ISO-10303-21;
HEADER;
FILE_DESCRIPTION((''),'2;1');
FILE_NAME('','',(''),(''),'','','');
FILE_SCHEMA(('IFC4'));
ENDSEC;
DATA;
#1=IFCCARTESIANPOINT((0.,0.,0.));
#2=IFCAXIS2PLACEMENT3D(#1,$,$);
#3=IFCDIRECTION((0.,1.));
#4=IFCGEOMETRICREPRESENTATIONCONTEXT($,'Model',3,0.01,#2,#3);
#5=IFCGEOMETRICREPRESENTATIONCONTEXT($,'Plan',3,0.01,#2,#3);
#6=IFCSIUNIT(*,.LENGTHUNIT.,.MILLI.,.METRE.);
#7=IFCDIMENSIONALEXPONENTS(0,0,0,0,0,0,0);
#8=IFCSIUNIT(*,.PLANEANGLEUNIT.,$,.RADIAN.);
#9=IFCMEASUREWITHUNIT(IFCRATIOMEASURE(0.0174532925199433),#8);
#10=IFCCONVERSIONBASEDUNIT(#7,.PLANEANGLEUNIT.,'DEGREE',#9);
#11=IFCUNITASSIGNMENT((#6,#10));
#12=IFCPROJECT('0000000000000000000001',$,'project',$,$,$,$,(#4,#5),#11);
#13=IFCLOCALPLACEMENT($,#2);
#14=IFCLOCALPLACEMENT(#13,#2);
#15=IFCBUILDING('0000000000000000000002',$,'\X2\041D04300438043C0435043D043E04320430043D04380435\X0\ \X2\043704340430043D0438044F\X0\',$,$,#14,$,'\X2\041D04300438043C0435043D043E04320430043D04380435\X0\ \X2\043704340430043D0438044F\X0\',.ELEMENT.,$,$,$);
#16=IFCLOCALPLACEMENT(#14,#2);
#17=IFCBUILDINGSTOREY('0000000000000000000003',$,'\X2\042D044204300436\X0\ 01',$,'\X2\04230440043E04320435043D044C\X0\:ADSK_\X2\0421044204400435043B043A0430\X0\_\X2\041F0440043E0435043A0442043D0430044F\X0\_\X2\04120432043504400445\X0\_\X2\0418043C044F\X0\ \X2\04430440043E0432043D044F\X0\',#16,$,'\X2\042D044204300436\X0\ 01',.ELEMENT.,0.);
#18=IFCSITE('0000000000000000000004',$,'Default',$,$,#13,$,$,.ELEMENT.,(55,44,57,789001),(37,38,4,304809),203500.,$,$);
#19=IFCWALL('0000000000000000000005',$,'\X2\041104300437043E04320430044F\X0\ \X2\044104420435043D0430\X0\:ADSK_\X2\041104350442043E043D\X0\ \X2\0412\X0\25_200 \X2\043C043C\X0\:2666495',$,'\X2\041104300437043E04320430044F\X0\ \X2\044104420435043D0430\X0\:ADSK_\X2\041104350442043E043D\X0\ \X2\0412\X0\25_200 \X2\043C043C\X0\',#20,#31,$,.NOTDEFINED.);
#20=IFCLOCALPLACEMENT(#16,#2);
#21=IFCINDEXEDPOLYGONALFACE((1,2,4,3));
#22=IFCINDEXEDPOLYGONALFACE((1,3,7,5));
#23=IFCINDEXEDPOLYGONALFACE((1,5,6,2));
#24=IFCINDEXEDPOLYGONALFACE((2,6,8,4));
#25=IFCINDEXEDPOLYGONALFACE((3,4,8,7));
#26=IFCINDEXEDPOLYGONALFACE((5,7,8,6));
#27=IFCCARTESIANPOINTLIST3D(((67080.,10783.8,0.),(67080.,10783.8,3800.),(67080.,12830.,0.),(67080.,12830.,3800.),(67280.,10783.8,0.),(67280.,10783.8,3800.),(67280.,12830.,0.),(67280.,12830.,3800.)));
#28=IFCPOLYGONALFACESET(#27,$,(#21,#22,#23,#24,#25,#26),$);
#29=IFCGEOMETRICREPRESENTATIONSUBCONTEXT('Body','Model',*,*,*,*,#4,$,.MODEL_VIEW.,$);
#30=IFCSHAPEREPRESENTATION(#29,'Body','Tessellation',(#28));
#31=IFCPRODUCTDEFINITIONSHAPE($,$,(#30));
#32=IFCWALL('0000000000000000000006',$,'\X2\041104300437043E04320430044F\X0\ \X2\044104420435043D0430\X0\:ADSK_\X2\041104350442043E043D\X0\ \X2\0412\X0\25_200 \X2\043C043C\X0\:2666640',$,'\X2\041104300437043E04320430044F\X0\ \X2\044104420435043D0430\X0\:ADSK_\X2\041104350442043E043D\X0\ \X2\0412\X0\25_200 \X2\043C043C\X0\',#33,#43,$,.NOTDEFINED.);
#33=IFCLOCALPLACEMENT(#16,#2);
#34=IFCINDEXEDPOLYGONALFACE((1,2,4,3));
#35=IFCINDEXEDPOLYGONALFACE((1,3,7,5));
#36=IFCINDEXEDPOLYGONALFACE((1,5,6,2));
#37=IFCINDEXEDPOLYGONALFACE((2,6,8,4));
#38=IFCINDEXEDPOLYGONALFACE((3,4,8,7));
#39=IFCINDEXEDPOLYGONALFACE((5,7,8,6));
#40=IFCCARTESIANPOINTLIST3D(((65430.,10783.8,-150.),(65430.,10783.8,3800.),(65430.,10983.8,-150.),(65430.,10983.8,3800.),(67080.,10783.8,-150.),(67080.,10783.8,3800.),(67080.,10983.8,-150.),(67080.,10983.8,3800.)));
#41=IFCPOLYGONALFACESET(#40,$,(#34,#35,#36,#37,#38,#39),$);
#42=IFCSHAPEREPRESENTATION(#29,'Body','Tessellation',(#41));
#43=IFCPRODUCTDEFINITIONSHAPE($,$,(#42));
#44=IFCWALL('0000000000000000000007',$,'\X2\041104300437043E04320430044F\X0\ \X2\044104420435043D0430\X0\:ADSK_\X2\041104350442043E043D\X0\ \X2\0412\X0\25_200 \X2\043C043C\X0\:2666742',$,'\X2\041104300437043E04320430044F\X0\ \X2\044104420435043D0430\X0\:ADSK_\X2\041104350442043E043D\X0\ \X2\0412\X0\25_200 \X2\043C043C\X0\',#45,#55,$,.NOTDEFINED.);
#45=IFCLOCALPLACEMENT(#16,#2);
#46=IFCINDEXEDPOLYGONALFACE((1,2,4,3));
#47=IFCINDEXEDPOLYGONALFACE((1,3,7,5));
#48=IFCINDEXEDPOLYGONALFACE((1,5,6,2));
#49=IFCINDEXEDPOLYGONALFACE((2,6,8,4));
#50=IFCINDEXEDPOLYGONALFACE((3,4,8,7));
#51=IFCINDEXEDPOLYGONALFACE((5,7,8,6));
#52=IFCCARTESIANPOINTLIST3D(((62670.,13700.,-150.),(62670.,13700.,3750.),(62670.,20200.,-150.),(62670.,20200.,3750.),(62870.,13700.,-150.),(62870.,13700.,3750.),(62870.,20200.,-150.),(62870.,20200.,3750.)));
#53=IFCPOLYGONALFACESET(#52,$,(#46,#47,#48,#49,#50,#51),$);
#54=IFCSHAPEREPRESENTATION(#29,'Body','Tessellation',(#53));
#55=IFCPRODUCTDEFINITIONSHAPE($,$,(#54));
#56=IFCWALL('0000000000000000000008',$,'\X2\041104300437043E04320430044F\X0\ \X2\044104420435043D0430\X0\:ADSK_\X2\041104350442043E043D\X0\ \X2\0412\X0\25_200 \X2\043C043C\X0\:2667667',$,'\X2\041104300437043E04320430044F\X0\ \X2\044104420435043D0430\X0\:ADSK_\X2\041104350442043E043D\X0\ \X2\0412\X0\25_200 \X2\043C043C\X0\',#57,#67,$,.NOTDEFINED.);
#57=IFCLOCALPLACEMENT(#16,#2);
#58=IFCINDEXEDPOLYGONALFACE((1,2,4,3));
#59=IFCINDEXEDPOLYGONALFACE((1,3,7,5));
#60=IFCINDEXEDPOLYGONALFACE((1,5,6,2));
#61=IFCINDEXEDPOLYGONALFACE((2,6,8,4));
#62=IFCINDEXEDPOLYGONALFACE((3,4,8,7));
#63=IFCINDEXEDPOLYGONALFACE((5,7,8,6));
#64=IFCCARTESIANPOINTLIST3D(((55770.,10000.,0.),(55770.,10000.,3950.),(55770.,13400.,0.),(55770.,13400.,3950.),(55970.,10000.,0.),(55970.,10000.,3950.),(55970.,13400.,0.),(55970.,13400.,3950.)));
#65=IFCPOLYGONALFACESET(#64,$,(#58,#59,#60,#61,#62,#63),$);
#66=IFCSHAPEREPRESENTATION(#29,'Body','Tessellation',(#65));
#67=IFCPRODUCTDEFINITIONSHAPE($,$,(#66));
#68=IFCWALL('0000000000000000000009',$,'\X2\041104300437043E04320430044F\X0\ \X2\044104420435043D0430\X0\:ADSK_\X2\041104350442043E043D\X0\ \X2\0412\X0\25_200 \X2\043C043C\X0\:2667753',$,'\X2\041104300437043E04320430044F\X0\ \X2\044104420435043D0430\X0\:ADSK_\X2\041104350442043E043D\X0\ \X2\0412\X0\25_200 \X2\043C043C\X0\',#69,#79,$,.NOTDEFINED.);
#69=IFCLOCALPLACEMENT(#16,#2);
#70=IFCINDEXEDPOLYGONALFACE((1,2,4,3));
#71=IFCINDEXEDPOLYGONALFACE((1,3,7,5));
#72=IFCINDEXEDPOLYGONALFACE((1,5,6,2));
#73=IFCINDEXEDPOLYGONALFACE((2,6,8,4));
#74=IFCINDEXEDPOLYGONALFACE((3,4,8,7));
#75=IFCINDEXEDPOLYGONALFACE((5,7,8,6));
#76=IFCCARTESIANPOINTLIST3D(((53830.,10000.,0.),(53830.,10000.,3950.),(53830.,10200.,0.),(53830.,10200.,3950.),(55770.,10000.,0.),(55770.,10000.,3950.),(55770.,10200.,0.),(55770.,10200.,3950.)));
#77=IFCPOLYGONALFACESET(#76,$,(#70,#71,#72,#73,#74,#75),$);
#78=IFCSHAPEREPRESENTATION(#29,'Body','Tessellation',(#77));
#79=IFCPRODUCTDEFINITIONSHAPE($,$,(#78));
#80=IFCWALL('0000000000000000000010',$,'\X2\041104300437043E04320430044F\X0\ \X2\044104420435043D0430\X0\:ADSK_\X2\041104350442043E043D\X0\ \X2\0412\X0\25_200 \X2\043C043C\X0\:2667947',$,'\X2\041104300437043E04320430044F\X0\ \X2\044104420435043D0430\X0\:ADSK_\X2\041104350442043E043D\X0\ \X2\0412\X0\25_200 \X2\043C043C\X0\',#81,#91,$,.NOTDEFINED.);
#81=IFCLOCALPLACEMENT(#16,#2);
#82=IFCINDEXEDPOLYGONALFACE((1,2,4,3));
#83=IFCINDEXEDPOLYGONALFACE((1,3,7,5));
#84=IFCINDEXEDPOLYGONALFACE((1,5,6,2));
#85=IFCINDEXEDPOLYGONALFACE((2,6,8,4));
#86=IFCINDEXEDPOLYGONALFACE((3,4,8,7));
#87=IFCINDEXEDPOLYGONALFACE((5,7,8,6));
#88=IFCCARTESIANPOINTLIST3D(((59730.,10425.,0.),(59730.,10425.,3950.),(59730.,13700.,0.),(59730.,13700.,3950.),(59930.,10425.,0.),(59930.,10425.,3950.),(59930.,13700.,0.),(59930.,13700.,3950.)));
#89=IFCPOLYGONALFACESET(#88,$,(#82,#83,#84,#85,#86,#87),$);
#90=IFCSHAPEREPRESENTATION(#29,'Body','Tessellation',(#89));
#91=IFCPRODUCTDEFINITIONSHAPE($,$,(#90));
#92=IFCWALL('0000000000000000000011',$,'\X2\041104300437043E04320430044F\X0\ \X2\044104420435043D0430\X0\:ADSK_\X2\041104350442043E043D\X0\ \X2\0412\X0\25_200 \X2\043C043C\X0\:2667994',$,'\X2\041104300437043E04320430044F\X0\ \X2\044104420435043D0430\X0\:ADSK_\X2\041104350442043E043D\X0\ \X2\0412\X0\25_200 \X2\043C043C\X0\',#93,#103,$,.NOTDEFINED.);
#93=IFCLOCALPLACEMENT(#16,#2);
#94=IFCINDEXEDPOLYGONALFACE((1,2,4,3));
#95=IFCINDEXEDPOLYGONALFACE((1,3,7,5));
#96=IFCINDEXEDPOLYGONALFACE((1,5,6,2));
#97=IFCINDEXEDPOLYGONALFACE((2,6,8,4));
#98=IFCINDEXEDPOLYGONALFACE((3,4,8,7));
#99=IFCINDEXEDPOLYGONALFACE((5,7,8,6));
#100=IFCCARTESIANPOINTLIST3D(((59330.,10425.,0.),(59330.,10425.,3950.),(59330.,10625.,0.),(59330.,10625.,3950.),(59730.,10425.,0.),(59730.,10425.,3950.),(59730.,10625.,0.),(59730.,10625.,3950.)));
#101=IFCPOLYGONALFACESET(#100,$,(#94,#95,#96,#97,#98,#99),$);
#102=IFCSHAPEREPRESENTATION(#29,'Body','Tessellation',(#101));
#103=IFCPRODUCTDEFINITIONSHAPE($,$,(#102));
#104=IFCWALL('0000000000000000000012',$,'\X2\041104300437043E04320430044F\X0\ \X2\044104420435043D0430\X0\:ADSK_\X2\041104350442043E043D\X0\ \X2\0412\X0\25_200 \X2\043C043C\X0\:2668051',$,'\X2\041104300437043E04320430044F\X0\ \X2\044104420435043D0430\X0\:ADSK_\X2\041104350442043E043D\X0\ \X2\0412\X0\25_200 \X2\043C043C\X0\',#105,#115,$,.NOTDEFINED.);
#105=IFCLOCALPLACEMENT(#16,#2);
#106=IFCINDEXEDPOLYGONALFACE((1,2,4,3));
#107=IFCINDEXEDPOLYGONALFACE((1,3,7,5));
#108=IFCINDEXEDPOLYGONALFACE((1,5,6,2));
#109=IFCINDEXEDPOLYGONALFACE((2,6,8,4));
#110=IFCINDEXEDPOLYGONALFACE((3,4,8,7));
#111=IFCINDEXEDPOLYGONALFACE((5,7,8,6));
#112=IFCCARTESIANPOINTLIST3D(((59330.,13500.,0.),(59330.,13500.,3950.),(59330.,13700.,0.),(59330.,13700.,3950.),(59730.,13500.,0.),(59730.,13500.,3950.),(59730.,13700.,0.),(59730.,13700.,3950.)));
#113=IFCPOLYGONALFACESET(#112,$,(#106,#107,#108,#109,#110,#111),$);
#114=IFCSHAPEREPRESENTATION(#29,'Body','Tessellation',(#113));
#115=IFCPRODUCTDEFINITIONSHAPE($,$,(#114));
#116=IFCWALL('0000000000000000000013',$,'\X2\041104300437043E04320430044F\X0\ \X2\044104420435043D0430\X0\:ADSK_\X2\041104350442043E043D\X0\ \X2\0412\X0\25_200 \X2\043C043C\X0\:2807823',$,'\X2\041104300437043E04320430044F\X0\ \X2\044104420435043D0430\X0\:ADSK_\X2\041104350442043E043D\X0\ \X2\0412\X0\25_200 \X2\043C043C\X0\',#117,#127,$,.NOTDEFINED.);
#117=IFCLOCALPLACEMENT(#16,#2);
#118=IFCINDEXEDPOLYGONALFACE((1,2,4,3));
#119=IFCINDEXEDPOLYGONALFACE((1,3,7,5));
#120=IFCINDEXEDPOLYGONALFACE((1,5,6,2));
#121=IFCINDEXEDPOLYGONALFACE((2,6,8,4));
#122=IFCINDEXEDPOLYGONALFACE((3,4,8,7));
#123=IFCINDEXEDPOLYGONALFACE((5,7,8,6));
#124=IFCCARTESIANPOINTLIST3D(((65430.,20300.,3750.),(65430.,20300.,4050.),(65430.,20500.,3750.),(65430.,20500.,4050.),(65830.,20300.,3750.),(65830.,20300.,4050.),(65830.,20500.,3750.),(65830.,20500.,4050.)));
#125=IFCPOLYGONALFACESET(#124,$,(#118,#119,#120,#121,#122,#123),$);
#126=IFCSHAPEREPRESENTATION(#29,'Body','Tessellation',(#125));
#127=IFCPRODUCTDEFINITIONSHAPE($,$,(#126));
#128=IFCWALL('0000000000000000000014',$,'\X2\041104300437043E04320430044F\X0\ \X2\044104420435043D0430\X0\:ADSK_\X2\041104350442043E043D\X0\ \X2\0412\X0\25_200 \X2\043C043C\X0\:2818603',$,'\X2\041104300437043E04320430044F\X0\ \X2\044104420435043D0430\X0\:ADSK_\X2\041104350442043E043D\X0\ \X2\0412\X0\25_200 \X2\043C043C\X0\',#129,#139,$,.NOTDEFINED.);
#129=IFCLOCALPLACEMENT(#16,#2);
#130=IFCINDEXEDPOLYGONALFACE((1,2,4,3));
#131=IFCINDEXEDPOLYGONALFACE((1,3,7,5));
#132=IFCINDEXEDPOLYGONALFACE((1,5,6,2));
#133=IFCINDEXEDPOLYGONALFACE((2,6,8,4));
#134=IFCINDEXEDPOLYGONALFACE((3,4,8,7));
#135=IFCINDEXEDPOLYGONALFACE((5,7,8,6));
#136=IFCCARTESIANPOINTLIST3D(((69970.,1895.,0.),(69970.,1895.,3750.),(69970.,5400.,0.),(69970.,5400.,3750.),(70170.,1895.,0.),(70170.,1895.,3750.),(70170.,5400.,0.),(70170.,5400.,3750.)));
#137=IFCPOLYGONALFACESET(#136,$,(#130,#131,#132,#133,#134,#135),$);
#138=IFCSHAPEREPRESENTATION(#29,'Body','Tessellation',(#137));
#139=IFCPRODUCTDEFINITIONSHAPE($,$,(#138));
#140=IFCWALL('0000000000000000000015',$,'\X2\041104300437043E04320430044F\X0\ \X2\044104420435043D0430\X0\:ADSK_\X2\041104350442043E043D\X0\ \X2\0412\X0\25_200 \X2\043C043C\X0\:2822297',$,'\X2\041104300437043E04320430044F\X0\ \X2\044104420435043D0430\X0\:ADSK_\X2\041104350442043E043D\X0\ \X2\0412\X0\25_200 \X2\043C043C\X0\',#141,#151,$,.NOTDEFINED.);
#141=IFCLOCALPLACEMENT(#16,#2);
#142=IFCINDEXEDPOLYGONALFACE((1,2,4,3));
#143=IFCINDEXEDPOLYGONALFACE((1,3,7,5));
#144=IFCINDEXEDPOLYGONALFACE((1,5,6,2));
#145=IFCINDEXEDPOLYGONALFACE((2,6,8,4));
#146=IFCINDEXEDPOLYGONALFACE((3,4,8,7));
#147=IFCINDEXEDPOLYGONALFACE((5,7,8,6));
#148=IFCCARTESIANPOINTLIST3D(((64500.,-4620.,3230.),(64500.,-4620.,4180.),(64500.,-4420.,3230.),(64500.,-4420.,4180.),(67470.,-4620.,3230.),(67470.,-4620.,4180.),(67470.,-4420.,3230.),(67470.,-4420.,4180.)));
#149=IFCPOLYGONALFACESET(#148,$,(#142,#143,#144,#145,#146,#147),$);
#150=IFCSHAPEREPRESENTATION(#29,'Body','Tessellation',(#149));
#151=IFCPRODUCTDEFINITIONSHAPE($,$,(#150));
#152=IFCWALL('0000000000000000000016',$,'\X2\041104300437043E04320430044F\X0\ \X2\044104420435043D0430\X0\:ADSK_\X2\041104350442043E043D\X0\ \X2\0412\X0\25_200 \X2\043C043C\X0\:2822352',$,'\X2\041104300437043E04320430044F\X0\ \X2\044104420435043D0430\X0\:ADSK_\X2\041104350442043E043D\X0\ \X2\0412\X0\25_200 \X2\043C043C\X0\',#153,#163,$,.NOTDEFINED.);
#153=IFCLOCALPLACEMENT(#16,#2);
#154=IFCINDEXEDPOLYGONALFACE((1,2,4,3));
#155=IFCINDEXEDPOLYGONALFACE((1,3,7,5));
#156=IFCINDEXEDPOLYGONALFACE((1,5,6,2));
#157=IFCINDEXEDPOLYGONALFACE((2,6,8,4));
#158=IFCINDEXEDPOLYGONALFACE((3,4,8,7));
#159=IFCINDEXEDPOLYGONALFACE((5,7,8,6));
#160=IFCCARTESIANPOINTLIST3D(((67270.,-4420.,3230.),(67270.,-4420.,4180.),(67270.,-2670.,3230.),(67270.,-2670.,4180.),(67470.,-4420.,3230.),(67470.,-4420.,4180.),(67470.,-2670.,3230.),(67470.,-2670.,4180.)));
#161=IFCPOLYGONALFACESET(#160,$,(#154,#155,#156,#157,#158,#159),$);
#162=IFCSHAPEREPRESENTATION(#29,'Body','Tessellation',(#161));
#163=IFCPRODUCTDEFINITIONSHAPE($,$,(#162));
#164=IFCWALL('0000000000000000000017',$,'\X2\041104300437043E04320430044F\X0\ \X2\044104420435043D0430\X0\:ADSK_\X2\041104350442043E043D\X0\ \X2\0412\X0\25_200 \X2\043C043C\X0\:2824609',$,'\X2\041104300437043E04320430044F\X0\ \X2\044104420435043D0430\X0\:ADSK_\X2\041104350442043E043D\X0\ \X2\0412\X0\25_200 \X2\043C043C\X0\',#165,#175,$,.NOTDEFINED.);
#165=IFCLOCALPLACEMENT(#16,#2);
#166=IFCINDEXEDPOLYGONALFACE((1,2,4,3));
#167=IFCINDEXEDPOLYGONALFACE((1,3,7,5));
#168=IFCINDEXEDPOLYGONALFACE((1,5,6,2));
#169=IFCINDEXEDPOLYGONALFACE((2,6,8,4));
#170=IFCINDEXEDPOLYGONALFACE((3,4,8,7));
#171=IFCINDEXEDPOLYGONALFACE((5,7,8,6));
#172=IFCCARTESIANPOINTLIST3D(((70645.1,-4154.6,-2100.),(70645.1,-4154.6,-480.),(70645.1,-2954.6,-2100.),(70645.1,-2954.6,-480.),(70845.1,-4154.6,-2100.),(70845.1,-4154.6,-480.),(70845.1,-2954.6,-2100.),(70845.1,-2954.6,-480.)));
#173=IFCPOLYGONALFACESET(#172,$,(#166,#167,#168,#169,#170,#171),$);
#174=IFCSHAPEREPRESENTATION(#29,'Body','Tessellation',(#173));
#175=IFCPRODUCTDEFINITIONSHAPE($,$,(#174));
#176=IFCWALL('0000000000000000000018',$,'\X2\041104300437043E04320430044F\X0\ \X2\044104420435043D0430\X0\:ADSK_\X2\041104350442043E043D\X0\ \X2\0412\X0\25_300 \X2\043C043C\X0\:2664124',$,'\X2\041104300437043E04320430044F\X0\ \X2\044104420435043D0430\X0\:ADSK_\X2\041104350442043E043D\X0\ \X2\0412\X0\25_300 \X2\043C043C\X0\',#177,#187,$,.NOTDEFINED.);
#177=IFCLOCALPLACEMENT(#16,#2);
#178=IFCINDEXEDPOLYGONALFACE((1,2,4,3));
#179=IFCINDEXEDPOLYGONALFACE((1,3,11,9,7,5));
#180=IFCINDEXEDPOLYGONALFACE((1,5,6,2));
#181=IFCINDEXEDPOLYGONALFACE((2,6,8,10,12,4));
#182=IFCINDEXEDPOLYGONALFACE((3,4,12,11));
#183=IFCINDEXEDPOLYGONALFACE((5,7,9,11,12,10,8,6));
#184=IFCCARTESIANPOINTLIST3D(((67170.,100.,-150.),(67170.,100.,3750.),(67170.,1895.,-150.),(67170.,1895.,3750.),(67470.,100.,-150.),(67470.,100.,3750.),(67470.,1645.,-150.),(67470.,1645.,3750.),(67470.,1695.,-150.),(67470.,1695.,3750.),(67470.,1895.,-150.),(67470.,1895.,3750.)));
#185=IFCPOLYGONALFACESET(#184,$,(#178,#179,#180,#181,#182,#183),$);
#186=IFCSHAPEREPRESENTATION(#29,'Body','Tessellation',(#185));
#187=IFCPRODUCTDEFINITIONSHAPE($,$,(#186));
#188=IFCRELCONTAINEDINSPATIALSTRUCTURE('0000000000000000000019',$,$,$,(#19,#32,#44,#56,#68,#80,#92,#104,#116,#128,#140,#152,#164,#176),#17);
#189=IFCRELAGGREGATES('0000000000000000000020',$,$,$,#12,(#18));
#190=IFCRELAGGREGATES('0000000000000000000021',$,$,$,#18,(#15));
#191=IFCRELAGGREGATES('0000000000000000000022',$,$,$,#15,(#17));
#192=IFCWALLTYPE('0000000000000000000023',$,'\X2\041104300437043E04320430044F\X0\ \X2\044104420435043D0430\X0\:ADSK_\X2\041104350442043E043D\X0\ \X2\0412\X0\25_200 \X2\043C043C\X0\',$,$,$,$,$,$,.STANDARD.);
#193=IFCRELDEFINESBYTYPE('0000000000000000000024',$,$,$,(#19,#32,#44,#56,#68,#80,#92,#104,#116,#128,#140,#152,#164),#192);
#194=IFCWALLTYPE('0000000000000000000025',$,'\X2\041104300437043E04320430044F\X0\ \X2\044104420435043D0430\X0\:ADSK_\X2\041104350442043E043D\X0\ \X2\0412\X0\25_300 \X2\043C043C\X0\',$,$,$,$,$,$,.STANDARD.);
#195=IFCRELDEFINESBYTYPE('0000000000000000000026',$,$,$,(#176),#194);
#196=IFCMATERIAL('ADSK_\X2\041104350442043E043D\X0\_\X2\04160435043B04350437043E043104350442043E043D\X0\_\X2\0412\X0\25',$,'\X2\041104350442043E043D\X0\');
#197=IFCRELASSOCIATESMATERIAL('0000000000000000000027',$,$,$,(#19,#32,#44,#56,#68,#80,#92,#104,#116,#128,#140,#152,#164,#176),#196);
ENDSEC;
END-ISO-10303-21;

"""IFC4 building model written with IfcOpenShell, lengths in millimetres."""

from ifc_helpers import new_model, entity, si_unit, converted_unit, direction, frame, origin, place, context, subcontext, project, spatial, indexed_curve, outline, extrude, material, type_object, element, save


model = new_model("IFC4")

# Units and contexts
model_context = context("Model", 3, precision=0.01, world=origin(), true_north=direction((0.0, 1.0)))
plan_context = context("Plan", 3, precision=0.01, world=origin(), true_north=direction((0.0, 1.0)))
body_context = subcontext(model_context, "Body", "Model", "MODEL_VIEW")
ifc_project = project(units=[si_unit("LENGTHUNIT", "METRE", prefix="MILLI"), converted_unit("PLANEANGLEUNIT", "DEGREE", entity("IfcRatioMeasure", 0.0174532925199433), si_unit("PLANEANGLEUNIT", "RADIAN"), dimensions=[0, 0, 0, 0, 0, 0, 0])], contexts=[model_context, plan_context])

# Site, building, storey
site_placement = place(None, origin())
site = spatial("IfcSite", under=ifc_project, at=site_placement, Name="Default", CompositionType="ELEMENT", RefLatitude=(55, 44, 57, 789001), RefLongitude=(37, 38, 4, 304809), RefElevation=203500.0)
building_placement = place(site_placement, origin())
building = spatial("IfcBuilding", under=site, at=building_placement, Name="Наименование здания", LongName="Наименование здания", CompositionType="ELEMENT")
storey_placement = place(building_placement, origin())
storey = spatial("IfcBuildingStorey", under=building, at=storey_placement, Name="Этаж 01", ObjectType="Уровень:ADSK_Стрелка_Проектная_Вверх_Имя уровня", LongName="Этаж 01", CompositionType="ELEMENT", Elevation=0.0)

# Walls
ifc_material = material(Name="ADSK_Бетон_Железобетон_В25", Category="Бетон")
wall_type_1 = type_object("IfcWallType", Name="Базовая стена:ADSK_Бетон В25_200 мм", PredefinedType="STANDARD")
wall_1_placement = place(storey_placement, frame((67180.0, 10783.8, 0.0), z_axis=(0.0, 0.0, 1.0), x_axis=(0.0, 1.0, 0.0)))
element("IfcWall", 1, at=wall_1_placement, inside=storey, type_object=wall_type_1, material=ifc_material, Name="Базовая стена:ADSK_Бетон В25_200 мм:2666495", ObjectType="Базовая стена:ADSK_Бетон В25_200 мм", PredefinedType="NOTDEFINED", context=body_context, shape_type="SweptSolid", body=[
    extrude(outline(indexed_curve([(2046.2, 100.0), (0.0, 100.0), (0.0, -100.0), (2046.2, -100.0), (2046.2, 100.0)], self_intersect=False)), origin(), (0.0, 0.0, 1.0), 3800.0),
])
wall_2_placement = place(storey_placement, frame((67080.0, 10883.8, -150.0), z_axis=(0.0, 0.0, 1.0), x_axis=(-1.0, 0.0, 0.0)))
element("IfcWall", 2, at=wall_2_placement, inside=storey, type_object=wall_type_1, material=ifc_material, Name="Базовая стена:ADSK_Бетон В25_200 мм:2666640", ObjectType="Базовая стена:ADSK_Бетон В25_200 мм", PredefinedType="NOTDEFINED", context=body_context, shape_type="SweptSolid", body=[
    extrude(outline(indexed_curve([(1650.0, 100.0), (0.0, 100.0), (0.0, -100.0), (1650.0, -100.0), (1650.0, 100.0)], self_intersect=False)), origin(), (0.0, 0.0, 1.0), 3950.0),
])
wall_3_placement = place(storey_placement, frame((62770.0, 13700.0, -150.0), z_axis=(0.0, 0.0, 1.0), x_axis=(0.0, 1.0, 0.0)))
element("IfcWall", 3, at=wall_3_placement, inside=storey, type_object=wall_type_1, material=ifc_material, Name="Базовая стена:ADSK_Бетон В25_200 мм:2666742", ObjectType="Базовая стена:ADSK_Бетон В25_200 мм", PredefinedType="NOTDEFINED", context=body_context, shape_type="SweptSolid", body=[
    extrude(outline(indexed_curve([(6500.0, 100.0), (0.0, 100.0), (0.0, -100.0), (6500.0, -100.0), (6500.0, 100.0)], self_intersect=False)), origin(), (0.0, 0.0, 1.0), 3900.0),
])
wall_4_placement = place(storey_placement, frame((55870.0, 13400.0, 0.0), z_axis=(0.0, 0.0, 1.0), x_axis=(0.0, -1.0, 0.0)))
element("IfcWall", 4, at=wall_4_placement, inside=storey, type_object=wall_type_1, material=ifc_material, Name="Базовая стена:ADSK_Бетон В25_200 мм:2667667", ObjectType="Базовая стена:ADSK_Бетон В25_200 мм", PredefinedType="NOTDEFINED", context=body_context, shape_type="SweptSolid", body=[
    extrude(outline(indexed_curve([(3400.0, 100.0), (0.0, 100.0), (0.0, -100.0), (3400.0, -100.0), (3400.0, 100.0)], self_intersect=False)), origin(), (0.0, 0.0, 1.0), 3950.0),
])
wall_5_placement = place(storey_placement, frame((55770.0, 10100.0, 0.0), z_axis=(0.0, 0.0, 1.0), x_axis=(-1.0, 0.0, 0.0)))
element("IfcWall", 5, at=wall_5_placement, inside=storey, type_object=wall_type_1, material=ifc_material, Name="Базовая стена:ADSK_Бетон В25_200 мм:2667753", ObjectType="Базовая стена:ADSK_Бетон В25_200 мм", PredefinedType="NOTDEFINED", context=body_context, shape_type="SweptSolid", body=[
    extrude(outline(indexed_curve([(1940.0, 100.0), (0.0, 100.0), (0.0, -100.0), (1940.0, -100.0), (1940.0, 100.0)], self_intersect=False)), origin(), (0.0, 0.0, 1.0), 3950.0),
])
wall_6_placement = place(storey_placement, frame((59830.0, 13700.0, 0.0), z_axis=(0.0, 0.0, 1.0), x_axis=(0.0, -1.0, 0.0)))
element("IfcWall", 6, at=wall_6_placement, inside=storey, type_object=wall_type_1, material=ifc_material, Name="Базовая стена:ADSK_Бетон В25_200 мм:2667947", ObjectType="Базовая стена:ADSK_Бетон В25_200 мм", PredefinedType="NOTDEFINED", context=body_context, shape_type="SweptSolid", body=[
    extrude(outline(indexed_curve([(3275.0, 100.0), (0.0, 100.0), (0.0, -100.0), (3275.0, -100.0), (3275.0, 100.0)], self_intersect=False)), origin(), (0.0, 0.0, 1.0), 3950.0),
])
wall_7_placement = place(storey_placement, frame((59730.0, 10525.0, 0.0), z_axis=(0.0, 0.0, 1.0), x_axis=(-1.0, 0.0, 0.0)))
element("IfcWall", 7, at=wall_7_placement, inside=storey, type_object=wall_type_1, material=ifc_material, Name="Базовая стена:ADSK_Бетон В25_200 мм:2667994", ObjectType="Базовая стена:ADSK_Бетон В25_200 мм", PredefinedType="NOTDEFINED", context=body_context, shape_type="SweptSolid", body=[
    extrude(outline(indexed_curve([(400.0, 100.0), (0.0, 100.0), (0.0, -100.0), (400.0, -100.0), (400.0, 100.0)], self_intersect=False)), origin(), (0.0, 0.0, 1.0), 3950.0),
])
wall_8_placement = place(storey_placement, frame((59330.0, 13600.0, 0.0)))
element("IfcWall", 8, at=wall_8_placement, inside=storey, type_object=wall_type_1, material=ifc_material, Name="Базовая стена:ADSK_Бетон В25_200 мм:2668051", ObjectType="Базовая стена:ADSK_Бетон В25_200 мм", PredefinedType="NOTDEFINED", context=body_context, shape_type="SweptSolid", body=[
    extrude(outline(indexed_curve([(400.0, 100.0), (0.0, 100.0), (0.0, -100.0), (400.0, -100.0), (400.0, 100.0)], self_intersect=False)), origin(), (0.0, 0.0, 1.0), 3950.0),
])
wall_9_placement = place(storey_placement, frame((65430.0, 20400.0, 3750.0)))
element("IfcWall", 9, at=wall_9_placement, inside=storey, type_object=wall_type_1, material=ifc_material, Name="Базовая стена:ADSK_Бетон В25_200 мм:2807823", ObjectType="Базовая стена:ADSK_Бетон В25_200 мм", PredefinedType="NOTDEFINED", context=body_context, shape_type="SweptSolid", body=[
    extrude(outline(indexed_curve([(400.0, 100.0), (0.0, 100.0), (0.0, -100.0), (400.0, -100.0), (400.0, 100.0)], self_intersect=False)), origin(), (0.0, 0.0, 1.0), 300.0),
])
wall_10_placement = place(storey_placement, frame((70070.0, 1895.0, 0.0), z_axis=(0.0, 0.0, 1.0), x_axis=(0.0, 1.0, 0.0)))
element("IfcWall", 10, at=wall_10_placement, inside=storey, type_object=wall_type_1, material=ifc_material, Name="Базовая стена:ADSK_Бетон В25_200 мм:2818603", ObjectType="Базовая стена:ADSK_Бетон В25_200 мм", PredefinedType="NOTDEFINED", context=body_context, shape_type="SweptSolid", body=[
    extrude(outline(indexed_curve([(3505.0, 100.0), (0.0, 100.0), (0.0, -100.0), (3505.0, -100.0), (3505.0, 100.0)], self_intersect=False)), origin(), (0.0, 0.0, 1.0), 3750.0),
])
wall_11_placement = place(storey_placement, frame((64500.0, -4520.0, 3230.0)))
element("IfcWall", 11, at=wall_11_placement, inside=storey, type_object=wall_type_1, material=ifc_material, Name="Базовая стена:ADSK_Бетон В25_200 мм:2822297", ObjectType="Базовая стена:ADSK_Бетон В25_200 мм", PredefinedType="NOTDEFINED", context=body_context, shape_type="SweptSolid", body=[
    extrude(outline(indexed_curve([(2970.0, 100.0), (0.0, 100.0), (0.0, -100.0), (2970.0, -100.0), (2970.0, 100.0)], self_intersect=False)), origin(), (0.0, 0.0, 1.0), 950.0),
])
wall_12_placement = place(storey_placement, frame((67370.0, -4420.0, 3230.0), z_axis=(0.0, 0.0, 1.0), x_axis=(0.0, 1.0, 0.0)))
element("IfcWall", 12, at=wall_12_placement, inside=storey, type_object=wall_type_1, material=ifc_material, Name="Базовая стена:ADSK_Бетон В25_200 мм:2822352", ObjectType="Базовая стена:ADSK_Бетон В25_200 мм", PredefinedType="NOTDEFINED", context=body_context, shape_type="SweptSolid", body=[
    extrude(outline(indexed_curve([(1750.0, 100.0), (0.0, 100.0), (0.0, -100.0), (1750.0, -100.0), (1750.0, 100.0)], self_intersect=False)), origin(), (0.0, 0.0, 1.0), 950.0),
])
wall_13_placement = place(storey_placement, frame((70745.1, -4154.6, -2100.0), z_axis=(0.0, 0.0, 1.0), x_axis=(0.0, 1.0, 0.0)))
element("IfcWall", 13, at=wall_13_placement, inside=storey, type_object=wall_type_1, material=ifc_material, Name="Базовая стена:ADSK_Бетон В25_200 мм:2824609", ObjectType="Базовая стена:ADSK_Бетон В25_200 мм", PredefinedType="NOTDEFINED", context=body_context, shape_type="SweptSolid", body=[
    extrude(outline(indexed_curve([(1200.0, 100.0), (0.0, 100.0), (0.0, -100.0), (1200.0, -100.0), (1200.0, 100.0)], self_intersect=False)), origin(), (0.0, 0.0, 1.0), 1620.0),
])
wall_type_2 = type_object("IfcWallType", Name="Базовая стена:ADSK_Бетон В25_300 мм", PredefinedType="STANDARD")
wall_14_placement = place(storey_placement, frame((67320.0, 1895.0, -150.0), z_axis=(0.0, 0.0, 1.0), x_axis=(0.0, -1.0, 0.0)))
element("IfcWall", 14, at=wall_14_placement, inside=storey, type_object=wall_type_2, material=ifc_material, Name="Базовая стена:ADSK_Бетон В25_300 мм:2664124", ObjectType="Базовая стена:ADSK_Бетон В25_300 мм", PredefinedType="NOTDEFINED", context=body_context, shape_type="SweptSolid", body=[
    extrude(outline(indexed_curve([(1795.0, -150.0), (1795.0, 150.0), (250.0, 150.0), (200.0, 150.0), (0.0, 150.0), (0.0, -150.0), (1795.0, -150.0)], self_intersect=False)), origin(), (0.0, 0.0, 1.0), 3900.0),
])

save(model, "model.ifc")
